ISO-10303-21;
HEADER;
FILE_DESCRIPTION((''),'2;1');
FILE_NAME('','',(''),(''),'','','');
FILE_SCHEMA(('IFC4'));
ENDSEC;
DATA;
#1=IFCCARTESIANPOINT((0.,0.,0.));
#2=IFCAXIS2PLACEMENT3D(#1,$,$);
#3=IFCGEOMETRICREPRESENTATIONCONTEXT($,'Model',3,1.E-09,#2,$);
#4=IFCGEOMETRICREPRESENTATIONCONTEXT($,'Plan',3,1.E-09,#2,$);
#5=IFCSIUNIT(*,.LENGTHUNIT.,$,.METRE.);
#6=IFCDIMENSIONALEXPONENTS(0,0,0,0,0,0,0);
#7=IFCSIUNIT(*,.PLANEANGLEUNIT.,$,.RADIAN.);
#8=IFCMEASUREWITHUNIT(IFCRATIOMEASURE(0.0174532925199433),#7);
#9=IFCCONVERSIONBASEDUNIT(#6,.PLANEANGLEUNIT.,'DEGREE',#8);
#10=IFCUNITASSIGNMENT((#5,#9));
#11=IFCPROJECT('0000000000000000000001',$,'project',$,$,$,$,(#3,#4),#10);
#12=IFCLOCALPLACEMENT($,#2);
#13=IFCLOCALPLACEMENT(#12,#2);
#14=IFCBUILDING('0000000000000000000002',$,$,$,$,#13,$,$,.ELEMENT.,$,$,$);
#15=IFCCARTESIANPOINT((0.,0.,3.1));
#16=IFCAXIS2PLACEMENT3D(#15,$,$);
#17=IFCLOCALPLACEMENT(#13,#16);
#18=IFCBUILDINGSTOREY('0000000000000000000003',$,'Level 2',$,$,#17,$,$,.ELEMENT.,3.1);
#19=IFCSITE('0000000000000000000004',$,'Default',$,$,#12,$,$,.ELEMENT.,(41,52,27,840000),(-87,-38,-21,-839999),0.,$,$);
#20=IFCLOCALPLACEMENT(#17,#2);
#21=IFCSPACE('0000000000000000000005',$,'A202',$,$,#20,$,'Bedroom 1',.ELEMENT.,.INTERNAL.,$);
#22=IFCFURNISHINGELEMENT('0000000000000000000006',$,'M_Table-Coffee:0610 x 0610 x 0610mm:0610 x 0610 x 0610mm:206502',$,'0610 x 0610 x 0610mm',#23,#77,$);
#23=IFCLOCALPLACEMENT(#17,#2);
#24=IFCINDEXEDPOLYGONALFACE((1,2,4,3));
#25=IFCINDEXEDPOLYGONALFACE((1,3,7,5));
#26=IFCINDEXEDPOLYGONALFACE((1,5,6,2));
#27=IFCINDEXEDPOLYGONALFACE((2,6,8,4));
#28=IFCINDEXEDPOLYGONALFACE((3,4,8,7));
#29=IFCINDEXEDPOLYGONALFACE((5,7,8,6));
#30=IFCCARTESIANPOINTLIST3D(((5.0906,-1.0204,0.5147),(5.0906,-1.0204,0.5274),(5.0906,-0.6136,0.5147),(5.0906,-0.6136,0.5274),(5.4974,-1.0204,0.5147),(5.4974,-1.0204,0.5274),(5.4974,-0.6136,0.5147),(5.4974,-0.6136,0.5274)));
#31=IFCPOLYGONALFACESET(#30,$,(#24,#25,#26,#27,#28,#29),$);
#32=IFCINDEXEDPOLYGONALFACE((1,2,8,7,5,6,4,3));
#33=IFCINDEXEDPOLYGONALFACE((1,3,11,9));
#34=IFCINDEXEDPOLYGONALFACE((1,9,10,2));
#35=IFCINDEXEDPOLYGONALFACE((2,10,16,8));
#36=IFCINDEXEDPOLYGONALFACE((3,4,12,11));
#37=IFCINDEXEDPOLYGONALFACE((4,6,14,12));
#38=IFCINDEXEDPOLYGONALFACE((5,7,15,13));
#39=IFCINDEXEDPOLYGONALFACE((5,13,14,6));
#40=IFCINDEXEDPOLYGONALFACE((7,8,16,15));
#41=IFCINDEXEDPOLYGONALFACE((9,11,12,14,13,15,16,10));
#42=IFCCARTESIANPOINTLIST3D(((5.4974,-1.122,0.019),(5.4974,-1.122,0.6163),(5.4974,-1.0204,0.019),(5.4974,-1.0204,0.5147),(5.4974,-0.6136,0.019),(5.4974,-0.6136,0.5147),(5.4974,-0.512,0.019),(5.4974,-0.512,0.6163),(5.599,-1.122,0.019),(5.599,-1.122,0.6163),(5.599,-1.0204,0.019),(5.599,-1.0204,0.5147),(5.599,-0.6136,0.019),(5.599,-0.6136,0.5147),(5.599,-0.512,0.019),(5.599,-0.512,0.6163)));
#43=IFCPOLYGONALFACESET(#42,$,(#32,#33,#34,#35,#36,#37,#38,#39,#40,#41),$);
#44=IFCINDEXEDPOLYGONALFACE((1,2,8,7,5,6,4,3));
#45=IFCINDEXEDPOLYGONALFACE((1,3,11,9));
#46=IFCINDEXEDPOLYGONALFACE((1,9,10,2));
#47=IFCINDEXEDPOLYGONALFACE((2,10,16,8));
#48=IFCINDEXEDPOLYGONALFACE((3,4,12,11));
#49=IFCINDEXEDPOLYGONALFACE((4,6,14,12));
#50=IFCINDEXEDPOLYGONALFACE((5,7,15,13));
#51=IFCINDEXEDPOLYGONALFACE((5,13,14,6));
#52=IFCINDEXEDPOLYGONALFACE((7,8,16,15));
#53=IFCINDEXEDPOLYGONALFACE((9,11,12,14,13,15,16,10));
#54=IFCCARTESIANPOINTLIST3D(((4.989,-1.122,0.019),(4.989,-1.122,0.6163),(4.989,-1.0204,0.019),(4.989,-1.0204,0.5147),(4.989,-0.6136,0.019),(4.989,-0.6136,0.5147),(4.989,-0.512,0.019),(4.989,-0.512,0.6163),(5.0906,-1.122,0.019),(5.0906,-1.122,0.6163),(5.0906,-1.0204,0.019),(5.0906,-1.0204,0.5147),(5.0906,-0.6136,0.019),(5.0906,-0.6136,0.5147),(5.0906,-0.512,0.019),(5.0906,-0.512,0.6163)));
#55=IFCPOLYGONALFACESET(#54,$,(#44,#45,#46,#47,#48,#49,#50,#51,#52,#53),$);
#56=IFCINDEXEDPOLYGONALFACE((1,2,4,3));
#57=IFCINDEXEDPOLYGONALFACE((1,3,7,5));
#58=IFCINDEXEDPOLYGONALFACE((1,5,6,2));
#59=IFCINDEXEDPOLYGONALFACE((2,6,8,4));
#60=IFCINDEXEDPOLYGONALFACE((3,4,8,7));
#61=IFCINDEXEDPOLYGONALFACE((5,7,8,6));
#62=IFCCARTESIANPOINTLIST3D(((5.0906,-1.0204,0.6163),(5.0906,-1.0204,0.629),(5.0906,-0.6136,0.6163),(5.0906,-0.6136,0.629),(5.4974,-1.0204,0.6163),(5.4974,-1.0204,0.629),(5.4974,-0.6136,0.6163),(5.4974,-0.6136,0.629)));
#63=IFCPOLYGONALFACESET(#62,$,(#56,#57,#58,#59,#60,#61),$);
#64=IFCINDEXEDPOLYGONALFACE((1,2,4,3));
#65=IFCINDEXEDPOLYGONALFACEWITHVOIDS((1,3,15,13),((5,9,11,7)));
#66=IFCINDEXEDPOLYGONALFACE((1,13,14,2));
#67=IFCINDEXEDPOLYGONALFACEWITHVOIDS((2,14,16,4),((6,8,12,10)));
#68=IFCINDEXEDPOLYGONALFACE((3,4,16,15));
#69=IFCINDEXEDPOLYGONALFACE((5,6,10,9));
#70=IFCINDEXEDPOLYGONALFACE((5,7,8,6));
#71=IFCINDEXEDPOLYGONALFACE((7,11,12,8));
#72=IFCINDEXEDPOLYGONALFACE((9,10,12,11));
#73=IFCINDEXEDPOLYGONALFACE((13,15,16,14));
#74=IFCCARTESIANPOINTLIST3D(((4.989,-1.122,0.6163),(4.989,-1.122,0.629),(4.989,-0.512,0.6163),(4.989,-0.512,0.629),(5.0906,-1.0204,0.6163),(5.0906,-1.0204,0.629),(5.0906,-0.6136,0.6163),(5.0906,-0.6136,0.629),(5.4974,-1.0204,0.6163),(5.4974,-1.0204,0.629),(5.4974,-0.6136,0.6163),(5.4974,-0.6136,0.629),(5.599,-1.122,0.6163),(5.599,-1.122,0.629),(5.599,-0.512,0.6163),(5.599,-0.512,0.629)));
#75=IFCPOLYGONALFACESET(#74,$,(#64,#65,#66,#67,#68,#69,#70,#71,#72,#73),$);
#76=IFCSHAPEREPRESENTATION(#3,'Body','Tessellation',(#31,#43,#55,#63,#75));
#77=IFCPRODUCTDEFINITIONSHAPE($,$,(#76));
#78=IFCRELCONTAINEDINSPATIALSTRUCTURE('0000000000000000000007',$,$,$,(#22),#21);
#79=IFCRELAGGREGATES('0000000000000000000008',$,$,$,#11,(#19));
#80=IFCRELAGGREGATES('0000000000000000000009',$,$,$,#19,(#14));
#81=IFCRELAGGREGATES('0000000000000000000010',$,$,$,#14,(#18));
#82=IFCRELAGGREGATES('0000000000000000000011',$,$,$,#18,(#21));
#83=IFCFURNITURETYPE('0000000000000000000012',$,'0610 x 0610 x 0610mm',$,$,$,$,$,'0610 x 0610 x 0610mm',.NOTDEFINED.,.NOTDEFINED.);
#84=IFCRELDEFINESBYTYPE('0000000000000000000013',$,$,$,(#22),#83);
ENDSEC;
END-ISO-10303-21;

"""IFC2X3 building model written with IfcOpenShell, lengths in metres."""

from ifc_helpers import new_model, entity, si_unit, converted_unit, frame, origin, origin_2d_with_axis, place, context, project, spatial, polyline, rectangle, outline, extrude, source, transform, mapped, type_object, type_shapes, element, save


model = new_model("IFC2X3")

# Units and contexts
model_context = context("Model", 3, precision=1e-09, world=origin())
plan_context = context("Plan", 3, precision=1e-09, world=origin())
ifc_project = project(units=[si_unit("LENGTHUNIT", "METRE"), converted_unit("PLANEANGLEUNIT", "DEGREE", entity("IfcRatioMeasure", 0.0174532925199433), si_unit("PLANEANGLEUNIT", "RADIAN"), dimensions=[0, 0, 0, 0, 0, 0, 0])], contexts=[model_context, plan_context])

# Site, building, storey
site_placement = place(None, origin())
site = spatial("IfcSite", under=ifc_project, at=site_placement, Name="Default", CompositionType="ELEMENT", RefLatitude=(41, 52, 27, 840000), RefLongitude=(-87, -38, -21, -839999), RefElevation=0.0)
building_placement = place(site_placement, origin())
building = spatial("IfcBuilding", under=site, at=building_placement, CompositionType="ELEMENT")
storey_placement = place(building_placement, frame((0.0, 0.0, 3.1)))
storey = spatial("IfcBuildingStorey", under=building, at=storey_placement, Name="Level 2", CompositionType="ELEMENT", Elevation=3.1)

# Shared definitions
furniture_type = type_object("IfcFurnitureType", Name="0610 x 0610 x 0610mm", ElementType="0610 x 0610 x 0610mm", AssemblyPlace="NOTDEFINED")
shared_shape_1 = source(origin(), model_context, "Body", "SweptSolid", [
    extrude(rectangle(XDim=0.4068, YDim=0.4068, at=origin_2d_with_axis()), frame((0.0183, 0.0952, 0.4957), z_axis=(0.0, 0.0, 1.0), x_axis=(-1.0, 0.0, 0.0)), (0.0, 0.0, 1.0), 0.0127),
    extrude(outline(polyline([(-0.2732, -0.305), (0.324, -0.305), (0.324, 0.305), (-0.2732, 0.305), (-0.2732, 0.2034), (0.2225, 0.2034), (0.2225, -0.2034), (-0.2732, -0.2034), (-0.2732, -0.305)])), frame((0.2217, 0.0952, 0.2732), z_axis=(1.0, 0.0, 0.0), x_axis=(0.0, 0.0, 1.0)), (0.0, 0.0, 1.0), 0.1016),
    extrude(outline(polyline([(-0.305, -0.3241), (0.305, -0.3241), (0.305, 0.2733), (0.2034, 0.2733), (0.2034, -0.2224), (-0.2034, -0.2224), (-0.2034, 0.2733), (-0.305, 0.2733), (-0.305, -0.3241)])), frame((-0.2867, 0.0952, 0.2733), z_axis=(1.0, 0.0, 0.0), x_axis=(0.0, -1.0, 0.0)), (0.0, 0.0, 1.0), 0.1016),
    extrude(rectangle(XDim=0.4068, YDim=0.4068, at=origin_2d_with_axis()), frame((0.0183, 0.0952, 0.5973), z_axis=(0.0, 0.0, 1.0), x_axis=(-1.0, 0.0, 0.0)), (0.0, 0.0, 1.0), 0.0127),
    extrude(outline(polyline([(-0.305, -0.305), (0.305, -0.305), (0.305, 0.305), (-0.305, 0.305), (-0.305, -0.305)]), holes=[polyline([(-0.2034, -0.2034), (-0.2034, 0.2034), (0.2034, 0.2034), (0.2034, -0.2034), (-0.2034, -0.2034)])]), frame((0.0183, 0.0952, 0.5973), z_axis=(0.0, 0.0, 1.0), x_axis=(-1.0, 0.0, 0.0)), (0.0, 0.0, 1.0), 0.0127),
])
type_shapes(furniture_type, [shared_shape_1])

# Shared definitions
space_1_placement = place(storey_placement, origin())
space_1 = spatial("IfcSpace", under=storey, at=space_1_placement, Name="A202", LongName="Bedroom 1", CompositionType="ELEMENT", InteriorOrExteriorSpace="INTERNAL")

# Furnishing element
furnishing_1_placement = place(space_1_placement, frame((5.2757, -0.9122, 0.019)))
element("IfcFurnishingElement", 1, at=furnishing_1_placement, inside=space_1, type_object=furniture_type, Name="M_Table-Coffee:0610 x 0610 x 0610mm:0610 x 0610 x 0610mm:206502", ObjectType="0610 x 0610 x 0610mm", context=model_context, shape_type="MappedRepresentation", body=[
    mapped(shared_shape_1, transform((0.0, 0.0, 0.0), scale=1.0)),
])

save(model, "model.ifc")
